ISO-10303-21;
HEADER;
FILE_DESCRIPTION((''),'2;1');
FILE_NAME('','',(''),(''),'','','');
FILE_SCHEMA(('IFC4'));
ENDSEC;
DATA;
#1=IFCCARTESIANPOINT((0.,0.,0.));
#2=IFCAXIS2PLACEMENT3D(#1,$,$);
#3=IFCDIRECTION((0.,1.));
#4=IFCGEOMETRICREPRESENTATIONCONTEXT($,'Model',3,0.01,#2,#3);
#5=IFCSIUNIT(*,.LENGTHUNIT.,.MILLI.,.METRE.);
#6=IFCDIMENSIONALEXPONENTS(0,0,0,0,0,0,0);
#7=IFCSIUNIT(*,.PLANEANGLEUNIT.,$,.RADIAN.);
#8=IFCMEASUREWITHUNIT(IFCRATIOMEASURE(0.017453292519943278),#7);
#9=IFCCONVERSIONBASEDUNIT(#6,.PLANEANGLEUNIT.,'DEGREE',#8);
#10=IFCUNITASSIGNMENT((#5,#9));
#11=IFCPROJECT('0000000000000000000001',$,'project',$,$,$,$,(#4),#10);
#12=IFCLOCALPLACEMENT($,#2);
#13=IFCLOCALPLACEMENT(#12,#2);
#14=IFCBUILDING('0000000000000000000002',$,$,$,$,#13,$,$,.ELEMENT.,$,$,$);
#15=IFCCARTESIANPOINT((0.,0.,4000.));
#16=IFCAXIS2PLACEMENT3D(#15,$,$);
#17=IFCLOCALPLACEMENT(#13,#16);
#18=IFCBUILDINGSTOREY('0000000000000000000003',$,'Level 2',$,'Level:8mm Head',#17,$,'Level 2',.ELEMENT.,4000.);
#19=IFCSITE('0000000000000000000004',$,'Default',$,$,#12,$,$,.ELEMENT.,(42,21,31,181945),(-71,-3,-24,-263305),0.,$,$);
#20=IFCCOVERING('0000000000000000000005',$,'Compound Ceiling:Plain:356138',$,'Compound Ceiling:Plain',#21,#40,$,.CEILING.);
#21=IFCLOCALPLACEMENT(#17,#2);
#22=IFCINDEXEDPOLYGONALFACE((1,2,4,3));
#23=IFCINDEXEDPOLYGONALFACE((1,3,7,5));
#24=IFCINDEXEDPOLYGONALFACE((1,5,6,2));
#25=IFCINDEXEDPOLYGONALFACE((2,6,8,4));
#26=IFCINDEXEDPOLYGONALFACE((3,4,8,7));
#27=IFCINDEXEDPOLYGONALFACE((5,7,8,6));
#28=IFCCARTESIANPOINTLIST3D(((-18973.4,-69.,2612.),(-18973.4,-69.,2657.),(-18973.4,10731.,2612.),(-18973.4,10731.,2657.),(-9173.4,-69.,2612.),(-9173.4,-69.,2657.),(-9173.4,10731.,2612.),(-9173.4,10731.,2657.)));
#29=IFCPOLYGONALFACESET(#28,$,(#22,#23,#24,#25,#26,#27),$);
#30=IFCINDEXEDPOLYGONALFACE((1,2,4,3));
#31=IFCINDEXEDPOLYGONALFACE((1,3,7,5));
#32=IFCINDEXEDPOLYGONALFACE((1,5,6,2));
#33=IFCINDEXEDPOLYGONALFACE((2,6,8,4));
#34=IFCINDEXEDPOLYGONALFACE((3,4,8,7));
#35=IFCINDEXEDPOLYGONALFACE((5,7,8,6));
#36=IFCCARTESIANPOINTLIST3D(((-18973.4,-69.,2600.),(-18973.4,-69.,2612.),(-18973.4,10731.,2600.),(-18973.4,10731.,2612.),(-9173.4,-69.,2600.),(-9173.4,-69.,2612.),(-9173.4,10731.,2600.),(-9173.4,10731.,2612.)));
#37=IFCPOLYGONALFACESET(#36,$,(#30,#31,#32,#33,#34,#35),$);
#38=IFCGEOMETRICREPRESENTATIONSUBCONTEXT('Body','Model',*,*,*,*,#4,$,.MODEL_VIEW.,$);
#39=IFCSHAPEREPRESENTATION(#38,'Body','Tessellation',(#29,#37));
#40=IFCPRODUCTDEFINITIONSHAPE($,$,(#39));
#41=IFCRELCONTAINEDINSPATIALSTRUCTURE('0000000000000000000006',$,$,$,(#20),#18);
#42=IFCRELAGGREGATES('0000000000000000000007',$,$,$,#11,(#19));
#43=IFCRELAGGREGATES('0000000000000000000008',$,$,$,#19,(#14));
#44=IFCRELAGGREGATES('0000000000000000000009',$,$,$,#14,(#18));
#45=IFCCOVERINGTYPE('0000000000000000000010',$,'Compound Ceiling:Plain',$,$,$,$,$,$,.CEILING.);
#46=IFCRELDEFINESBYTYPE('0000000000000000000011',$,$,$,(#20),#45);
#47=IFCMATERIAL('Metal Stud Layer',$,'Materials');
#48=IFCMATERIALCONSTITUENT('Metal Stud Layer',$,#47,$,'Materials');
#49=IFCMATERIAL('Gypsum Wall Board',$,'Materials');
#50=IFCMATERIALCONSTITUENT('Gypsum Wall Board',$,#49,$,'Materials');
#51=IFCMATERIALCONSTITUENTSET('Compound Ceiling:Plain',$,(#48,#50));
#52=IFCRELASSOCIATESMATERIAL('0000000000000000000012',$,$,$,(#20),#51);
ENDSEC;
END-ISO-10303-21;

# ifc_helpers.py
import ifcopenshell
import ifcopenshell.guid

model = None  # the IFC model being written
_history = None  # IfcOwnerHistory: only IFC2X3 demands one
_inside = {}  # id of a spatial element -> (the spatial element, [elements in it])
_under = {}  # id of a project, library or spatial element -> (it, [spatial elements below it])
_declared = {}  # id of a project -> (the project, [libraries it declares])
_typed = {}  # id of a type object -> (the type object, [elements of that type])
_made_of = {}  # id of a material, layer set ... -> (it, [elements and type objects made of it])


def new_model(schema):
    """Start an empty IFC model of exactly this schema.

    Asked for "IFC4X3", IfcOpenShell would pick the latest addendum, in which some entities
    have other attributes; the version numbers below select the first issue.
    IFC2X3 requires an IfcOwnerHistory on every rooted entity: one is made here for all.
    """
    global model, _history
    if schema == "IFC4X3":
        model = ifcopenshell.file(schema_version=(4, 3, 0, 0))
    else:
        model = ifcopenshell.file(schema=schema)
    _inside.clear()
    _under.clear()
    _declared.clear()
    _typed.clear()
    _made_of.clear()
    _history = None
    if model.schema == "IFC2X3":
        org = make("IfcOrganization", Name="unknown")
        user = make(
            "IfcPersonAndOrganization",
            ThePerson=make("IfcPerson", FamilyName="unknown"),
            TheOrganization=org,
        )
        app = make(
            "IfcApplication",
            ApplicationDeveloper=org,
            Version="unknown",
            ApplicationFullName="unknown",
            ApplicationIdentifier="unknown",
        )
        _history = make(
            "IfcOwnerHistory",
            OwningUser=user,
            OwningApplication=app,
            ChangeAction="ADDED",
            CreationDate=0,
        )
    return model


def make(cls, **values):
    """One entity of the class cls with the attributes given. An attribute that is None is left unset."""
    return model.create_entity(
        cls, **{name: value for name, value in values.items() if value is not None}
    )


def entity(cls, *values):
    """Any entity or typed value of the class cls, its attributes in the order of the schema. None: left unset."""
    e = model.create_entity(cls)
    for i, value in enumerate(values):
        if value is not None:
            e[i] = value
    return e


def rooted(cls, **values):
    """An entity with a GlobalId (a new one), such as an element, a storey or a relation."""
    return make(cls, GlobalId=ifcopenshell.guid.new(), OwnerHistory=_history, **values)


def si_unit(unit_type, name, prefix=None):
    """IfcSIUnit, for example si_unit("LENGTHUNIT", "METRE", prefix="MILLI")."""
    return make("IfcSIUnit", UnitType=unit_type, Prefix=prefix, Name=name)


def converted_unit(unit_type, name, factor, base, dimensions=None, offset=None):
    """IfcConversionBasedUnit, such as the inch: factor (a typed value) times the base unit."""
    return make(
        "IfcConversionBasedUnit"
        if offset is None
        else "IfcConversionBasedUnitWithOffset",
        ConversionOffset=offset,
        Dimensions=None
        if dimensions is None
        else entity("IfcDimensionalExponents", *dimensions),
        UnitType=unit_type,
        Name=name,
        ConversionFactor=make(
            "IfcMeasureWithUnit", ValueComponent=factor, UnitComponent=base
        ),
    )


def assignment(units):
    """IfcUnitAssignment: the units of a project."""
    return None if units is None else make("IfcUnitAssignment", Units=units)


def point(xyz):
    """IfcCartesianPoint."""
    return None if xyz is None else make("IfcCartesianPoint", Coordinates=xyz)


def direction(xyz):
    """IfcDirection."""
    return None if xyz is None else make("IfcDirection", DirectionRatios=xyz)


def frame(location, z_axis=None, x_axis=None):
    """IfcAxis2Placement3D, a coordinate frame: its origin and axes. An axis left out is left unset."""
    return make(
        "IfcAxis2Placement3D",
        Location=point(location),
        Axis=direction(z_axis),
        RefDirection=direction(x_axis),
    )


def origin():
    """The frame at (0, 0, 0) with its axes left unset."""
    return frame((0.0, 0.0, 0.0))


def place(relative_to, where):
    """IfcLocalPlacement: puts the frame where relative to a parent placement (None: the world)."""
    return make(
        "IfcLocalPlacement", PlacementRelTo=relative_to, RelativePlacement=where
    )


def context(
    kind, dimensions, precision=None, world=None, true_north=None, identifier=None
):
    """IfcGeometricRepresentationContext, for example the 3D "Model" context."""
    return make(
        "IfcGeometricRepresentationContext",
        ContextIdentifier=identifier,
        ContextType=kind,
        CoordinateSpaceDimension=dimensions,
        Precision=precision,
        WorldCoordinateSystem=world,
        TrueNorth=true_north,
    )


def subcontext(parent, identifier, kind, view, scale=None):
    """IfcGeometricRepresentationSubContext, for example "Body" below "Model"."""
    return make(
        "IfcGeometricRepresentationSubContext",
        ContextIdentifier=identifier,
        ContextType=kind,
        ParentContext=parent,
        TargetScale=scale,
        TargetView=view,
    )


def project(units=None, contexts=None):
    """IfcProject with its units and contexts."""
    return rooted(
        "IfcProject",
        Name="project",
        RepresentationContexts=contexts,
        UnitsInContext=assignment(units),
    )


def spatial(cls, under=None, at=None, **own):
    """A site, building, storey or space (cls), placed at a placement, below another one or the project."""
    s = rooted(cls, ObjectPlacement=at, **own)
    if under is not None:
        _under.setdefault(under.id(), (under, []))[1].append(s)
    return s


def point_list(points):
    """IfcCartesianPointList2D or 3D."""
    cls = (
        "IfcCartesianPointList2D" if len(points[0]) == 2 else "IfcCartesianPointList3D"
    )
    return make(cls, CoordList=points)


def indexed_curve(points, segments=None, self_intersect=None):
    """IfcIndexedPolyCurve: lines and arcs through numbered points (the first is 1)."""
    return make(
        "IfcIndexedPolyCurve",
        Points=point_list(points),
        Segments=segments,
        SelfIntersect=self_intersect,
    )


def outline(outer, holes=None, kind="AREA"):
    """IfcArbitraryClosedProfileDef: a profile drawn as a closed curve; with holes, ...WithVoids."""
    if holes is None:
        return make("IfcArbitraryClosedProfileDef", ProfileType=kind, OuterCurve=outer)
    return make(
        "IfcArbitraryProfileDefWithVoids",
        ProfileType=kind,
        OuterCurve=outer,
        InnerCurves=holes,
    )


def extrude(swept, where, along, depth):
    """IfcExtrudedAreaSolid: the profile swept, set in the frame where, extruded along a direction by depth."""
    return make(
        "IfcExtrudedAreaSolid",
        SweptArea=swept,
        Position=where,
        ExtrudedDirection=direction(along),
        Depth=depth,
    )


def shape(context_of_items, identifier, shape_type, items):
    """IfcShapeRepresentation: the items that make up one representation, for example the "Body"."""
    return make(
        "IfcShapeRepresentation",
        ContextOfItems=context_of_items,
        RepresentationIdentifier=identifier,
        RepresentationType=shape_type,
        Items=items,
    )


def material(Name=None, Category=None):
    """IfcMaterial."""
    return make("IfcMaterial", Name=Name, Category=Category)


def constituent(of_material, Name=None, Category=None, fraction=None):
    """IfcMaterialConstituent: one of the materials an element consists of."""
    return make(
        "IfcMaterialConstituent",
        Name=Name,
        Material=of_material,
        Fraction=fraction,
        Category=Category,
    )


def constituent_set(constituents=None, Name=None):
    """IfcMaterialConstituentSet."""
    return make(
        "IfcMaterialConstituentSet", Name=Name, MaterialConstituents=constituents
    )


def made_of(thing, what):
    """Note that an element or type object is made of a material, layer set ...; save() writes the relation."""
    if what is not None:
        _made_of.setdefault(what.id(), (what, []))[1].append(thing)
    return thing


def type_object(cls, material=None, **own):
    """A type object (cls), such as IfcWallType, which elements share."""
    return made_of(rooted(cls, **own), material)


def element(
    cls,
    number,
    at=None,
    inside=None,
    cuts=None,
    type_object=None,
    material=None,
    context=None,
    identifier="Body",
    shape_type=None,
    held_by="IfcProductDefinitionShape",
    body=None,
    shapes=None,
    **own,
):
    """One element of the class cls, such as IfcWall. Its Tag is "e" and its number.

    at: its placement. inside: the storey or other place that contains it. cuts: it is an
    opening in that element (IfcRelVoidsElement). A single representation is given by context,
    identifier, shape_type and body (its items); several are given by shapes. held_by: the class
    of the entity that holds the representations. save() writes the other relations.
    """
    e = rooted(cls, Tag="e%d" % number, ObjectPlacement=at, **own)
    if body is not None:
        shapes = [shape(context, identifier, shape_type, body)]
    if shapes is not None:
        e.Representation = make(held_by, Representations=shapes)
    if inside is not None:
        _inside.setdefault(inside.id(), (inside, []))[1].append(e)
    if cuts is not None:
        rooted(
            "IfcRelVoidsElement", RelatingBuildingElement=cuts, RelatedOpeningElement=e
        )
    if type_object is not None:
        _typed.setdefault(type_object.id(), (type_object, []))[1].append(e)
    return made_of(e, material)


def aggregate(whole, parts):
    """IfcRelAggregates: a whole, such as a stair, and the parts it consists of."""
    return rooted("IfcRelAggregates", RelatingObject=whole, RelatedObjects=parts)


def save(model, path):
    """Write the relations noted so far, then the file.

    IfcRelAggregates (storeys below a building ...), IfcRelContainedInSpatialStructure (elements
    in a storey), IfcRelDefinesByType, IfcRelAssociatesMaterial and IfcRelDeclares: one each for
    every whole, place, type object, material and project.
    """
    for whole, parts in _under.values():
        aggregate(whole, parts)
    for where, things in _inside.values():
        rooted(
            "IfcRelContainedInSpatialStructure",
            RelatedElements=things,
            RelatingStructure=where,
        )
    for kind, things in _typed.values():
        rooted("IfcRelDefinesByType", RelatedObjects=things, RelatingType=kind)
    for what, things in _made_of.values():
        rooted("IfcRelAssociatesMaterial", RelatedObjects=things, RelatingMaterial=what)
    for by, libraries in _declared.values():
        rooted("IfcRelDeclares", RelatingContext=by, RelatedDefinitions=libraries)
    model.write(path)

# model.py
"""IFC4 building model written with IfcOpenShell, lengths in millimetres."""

from ifc_helpers import new_model, entity, si_unit, converted_unit, direction, frame, origin, place, context, subcontext, project, spatial, indexed_curve, outline, extrude, material, constituent, constituent_set, type_object, element, save


model = new_model("IFC4")

# Units and contexts
model_context = context("Model", 3, precision=0.01, world=origin(), true_north=direction((0.0, 1.0)))
body_context = subcontext(model_context, "Body", "Model", "MODEL_VIEW")
ifc_project = project(units=[si_unit("LENGTHUNIT", "METRE", prefix="MILLI"), converted_unit("PLANEANGLEUNIT", "DEGREE", entity("IfcRatioMeasure", 0.017453292519943278), si_unit("PLANEANGLEUNIT", "RADIAN"), dimensions=[0, 0, 0, 0, 0, 0, 0])], contexts=[model_context])

# Site, building, storey
site_placement = place(None, origin())
site = spatial("IfcSite", under=ifc_project, at=site_placement, Name="Default", CompositionType="ELEMENT", RefLatitude=(42, 21, 31, 181945), RefLongitude=(-71, -3, -24, -263305), RefElevation=0.0)
building_placement = place(site_placement, origin())
building = spatial("IfcBuilding", under=site, at=building_placement, CompositionType="ELEMENT")
storey_placement = place(building_placement, frame((0.0, 0.0, 4000.0)))
storey = spatial("IfcBuildingStorey", under=building, at=storey_placement, Name="Level 2", ObjectType="Level:8mm Head", LongName="Level 2", CompositionType="ELEMENT", Elevation=4000.0)

# Covering
ifc_material_1 = material(Name="Metal Stud Layer", Category="Materials")
ifc_constituent_1 = constituent(ifc_material_1, Name="Metal Stud Layer", Category="Materials")
ifc_material_2 = material(Name="Gypsum Wall Board", Category="Materials")
ifc_constituent_2 = constituent(ifc_material_2, Name="Gypsum Wall Board", Category="Materials")
ifc_constituent_set = constituent_set(constituents=[ifc_constituent_1, ifc_constituent_2], Name="Compound Ceiling:Plain")
covering_type = type_object("IfcCoveringType", Name="Compound Ceiling:Plain", PredefinedType="CEILING")
covering_placement = place(storey_placement, origin())
element("IfcCovering", 1, at=covering_placement, inside=storey, type_object=covering_type, material=ifc_constituent_set, Name="Compound Ceiling:Plain:356138", ObjectType="Compound Ceiling:Plain", PredefinedType="CEILING", context=body_context, shape_type="SweptSolid", body=[
    extrude(outline(indexed_curve([(-5400.0, -4900.0), (5400.0, -4900.0), (5400.0, 4900.0), (-5400.0, 4900.0), (-5400.0, -4900.0)], self_intersect=False)), frame((-14073.4, 5331.0, 2612.0), z_axis=(0.0, 0.0, 1.0), x_axis=(0.0, -1.0, 0.0)), (0.0, 0.0, 1.0), 45.0),
    extrude(outline(indexed_curve([(-4900.0, -5400.0), (4900.0, -5400.0), (4900.0, 5400.0), (-4900.0, 5400.0), (-4900.0, -5400.0)], self_intersect=False)), frame((-14073.4, 5331.0, 2600.0), z_axis=(0.0, 0.0, 1.0), x_axis=(-1.0, 0.0, 0.0)), (0.0, 0.0, 1.0), 12.0),
])

save(model, "model.ifc")
